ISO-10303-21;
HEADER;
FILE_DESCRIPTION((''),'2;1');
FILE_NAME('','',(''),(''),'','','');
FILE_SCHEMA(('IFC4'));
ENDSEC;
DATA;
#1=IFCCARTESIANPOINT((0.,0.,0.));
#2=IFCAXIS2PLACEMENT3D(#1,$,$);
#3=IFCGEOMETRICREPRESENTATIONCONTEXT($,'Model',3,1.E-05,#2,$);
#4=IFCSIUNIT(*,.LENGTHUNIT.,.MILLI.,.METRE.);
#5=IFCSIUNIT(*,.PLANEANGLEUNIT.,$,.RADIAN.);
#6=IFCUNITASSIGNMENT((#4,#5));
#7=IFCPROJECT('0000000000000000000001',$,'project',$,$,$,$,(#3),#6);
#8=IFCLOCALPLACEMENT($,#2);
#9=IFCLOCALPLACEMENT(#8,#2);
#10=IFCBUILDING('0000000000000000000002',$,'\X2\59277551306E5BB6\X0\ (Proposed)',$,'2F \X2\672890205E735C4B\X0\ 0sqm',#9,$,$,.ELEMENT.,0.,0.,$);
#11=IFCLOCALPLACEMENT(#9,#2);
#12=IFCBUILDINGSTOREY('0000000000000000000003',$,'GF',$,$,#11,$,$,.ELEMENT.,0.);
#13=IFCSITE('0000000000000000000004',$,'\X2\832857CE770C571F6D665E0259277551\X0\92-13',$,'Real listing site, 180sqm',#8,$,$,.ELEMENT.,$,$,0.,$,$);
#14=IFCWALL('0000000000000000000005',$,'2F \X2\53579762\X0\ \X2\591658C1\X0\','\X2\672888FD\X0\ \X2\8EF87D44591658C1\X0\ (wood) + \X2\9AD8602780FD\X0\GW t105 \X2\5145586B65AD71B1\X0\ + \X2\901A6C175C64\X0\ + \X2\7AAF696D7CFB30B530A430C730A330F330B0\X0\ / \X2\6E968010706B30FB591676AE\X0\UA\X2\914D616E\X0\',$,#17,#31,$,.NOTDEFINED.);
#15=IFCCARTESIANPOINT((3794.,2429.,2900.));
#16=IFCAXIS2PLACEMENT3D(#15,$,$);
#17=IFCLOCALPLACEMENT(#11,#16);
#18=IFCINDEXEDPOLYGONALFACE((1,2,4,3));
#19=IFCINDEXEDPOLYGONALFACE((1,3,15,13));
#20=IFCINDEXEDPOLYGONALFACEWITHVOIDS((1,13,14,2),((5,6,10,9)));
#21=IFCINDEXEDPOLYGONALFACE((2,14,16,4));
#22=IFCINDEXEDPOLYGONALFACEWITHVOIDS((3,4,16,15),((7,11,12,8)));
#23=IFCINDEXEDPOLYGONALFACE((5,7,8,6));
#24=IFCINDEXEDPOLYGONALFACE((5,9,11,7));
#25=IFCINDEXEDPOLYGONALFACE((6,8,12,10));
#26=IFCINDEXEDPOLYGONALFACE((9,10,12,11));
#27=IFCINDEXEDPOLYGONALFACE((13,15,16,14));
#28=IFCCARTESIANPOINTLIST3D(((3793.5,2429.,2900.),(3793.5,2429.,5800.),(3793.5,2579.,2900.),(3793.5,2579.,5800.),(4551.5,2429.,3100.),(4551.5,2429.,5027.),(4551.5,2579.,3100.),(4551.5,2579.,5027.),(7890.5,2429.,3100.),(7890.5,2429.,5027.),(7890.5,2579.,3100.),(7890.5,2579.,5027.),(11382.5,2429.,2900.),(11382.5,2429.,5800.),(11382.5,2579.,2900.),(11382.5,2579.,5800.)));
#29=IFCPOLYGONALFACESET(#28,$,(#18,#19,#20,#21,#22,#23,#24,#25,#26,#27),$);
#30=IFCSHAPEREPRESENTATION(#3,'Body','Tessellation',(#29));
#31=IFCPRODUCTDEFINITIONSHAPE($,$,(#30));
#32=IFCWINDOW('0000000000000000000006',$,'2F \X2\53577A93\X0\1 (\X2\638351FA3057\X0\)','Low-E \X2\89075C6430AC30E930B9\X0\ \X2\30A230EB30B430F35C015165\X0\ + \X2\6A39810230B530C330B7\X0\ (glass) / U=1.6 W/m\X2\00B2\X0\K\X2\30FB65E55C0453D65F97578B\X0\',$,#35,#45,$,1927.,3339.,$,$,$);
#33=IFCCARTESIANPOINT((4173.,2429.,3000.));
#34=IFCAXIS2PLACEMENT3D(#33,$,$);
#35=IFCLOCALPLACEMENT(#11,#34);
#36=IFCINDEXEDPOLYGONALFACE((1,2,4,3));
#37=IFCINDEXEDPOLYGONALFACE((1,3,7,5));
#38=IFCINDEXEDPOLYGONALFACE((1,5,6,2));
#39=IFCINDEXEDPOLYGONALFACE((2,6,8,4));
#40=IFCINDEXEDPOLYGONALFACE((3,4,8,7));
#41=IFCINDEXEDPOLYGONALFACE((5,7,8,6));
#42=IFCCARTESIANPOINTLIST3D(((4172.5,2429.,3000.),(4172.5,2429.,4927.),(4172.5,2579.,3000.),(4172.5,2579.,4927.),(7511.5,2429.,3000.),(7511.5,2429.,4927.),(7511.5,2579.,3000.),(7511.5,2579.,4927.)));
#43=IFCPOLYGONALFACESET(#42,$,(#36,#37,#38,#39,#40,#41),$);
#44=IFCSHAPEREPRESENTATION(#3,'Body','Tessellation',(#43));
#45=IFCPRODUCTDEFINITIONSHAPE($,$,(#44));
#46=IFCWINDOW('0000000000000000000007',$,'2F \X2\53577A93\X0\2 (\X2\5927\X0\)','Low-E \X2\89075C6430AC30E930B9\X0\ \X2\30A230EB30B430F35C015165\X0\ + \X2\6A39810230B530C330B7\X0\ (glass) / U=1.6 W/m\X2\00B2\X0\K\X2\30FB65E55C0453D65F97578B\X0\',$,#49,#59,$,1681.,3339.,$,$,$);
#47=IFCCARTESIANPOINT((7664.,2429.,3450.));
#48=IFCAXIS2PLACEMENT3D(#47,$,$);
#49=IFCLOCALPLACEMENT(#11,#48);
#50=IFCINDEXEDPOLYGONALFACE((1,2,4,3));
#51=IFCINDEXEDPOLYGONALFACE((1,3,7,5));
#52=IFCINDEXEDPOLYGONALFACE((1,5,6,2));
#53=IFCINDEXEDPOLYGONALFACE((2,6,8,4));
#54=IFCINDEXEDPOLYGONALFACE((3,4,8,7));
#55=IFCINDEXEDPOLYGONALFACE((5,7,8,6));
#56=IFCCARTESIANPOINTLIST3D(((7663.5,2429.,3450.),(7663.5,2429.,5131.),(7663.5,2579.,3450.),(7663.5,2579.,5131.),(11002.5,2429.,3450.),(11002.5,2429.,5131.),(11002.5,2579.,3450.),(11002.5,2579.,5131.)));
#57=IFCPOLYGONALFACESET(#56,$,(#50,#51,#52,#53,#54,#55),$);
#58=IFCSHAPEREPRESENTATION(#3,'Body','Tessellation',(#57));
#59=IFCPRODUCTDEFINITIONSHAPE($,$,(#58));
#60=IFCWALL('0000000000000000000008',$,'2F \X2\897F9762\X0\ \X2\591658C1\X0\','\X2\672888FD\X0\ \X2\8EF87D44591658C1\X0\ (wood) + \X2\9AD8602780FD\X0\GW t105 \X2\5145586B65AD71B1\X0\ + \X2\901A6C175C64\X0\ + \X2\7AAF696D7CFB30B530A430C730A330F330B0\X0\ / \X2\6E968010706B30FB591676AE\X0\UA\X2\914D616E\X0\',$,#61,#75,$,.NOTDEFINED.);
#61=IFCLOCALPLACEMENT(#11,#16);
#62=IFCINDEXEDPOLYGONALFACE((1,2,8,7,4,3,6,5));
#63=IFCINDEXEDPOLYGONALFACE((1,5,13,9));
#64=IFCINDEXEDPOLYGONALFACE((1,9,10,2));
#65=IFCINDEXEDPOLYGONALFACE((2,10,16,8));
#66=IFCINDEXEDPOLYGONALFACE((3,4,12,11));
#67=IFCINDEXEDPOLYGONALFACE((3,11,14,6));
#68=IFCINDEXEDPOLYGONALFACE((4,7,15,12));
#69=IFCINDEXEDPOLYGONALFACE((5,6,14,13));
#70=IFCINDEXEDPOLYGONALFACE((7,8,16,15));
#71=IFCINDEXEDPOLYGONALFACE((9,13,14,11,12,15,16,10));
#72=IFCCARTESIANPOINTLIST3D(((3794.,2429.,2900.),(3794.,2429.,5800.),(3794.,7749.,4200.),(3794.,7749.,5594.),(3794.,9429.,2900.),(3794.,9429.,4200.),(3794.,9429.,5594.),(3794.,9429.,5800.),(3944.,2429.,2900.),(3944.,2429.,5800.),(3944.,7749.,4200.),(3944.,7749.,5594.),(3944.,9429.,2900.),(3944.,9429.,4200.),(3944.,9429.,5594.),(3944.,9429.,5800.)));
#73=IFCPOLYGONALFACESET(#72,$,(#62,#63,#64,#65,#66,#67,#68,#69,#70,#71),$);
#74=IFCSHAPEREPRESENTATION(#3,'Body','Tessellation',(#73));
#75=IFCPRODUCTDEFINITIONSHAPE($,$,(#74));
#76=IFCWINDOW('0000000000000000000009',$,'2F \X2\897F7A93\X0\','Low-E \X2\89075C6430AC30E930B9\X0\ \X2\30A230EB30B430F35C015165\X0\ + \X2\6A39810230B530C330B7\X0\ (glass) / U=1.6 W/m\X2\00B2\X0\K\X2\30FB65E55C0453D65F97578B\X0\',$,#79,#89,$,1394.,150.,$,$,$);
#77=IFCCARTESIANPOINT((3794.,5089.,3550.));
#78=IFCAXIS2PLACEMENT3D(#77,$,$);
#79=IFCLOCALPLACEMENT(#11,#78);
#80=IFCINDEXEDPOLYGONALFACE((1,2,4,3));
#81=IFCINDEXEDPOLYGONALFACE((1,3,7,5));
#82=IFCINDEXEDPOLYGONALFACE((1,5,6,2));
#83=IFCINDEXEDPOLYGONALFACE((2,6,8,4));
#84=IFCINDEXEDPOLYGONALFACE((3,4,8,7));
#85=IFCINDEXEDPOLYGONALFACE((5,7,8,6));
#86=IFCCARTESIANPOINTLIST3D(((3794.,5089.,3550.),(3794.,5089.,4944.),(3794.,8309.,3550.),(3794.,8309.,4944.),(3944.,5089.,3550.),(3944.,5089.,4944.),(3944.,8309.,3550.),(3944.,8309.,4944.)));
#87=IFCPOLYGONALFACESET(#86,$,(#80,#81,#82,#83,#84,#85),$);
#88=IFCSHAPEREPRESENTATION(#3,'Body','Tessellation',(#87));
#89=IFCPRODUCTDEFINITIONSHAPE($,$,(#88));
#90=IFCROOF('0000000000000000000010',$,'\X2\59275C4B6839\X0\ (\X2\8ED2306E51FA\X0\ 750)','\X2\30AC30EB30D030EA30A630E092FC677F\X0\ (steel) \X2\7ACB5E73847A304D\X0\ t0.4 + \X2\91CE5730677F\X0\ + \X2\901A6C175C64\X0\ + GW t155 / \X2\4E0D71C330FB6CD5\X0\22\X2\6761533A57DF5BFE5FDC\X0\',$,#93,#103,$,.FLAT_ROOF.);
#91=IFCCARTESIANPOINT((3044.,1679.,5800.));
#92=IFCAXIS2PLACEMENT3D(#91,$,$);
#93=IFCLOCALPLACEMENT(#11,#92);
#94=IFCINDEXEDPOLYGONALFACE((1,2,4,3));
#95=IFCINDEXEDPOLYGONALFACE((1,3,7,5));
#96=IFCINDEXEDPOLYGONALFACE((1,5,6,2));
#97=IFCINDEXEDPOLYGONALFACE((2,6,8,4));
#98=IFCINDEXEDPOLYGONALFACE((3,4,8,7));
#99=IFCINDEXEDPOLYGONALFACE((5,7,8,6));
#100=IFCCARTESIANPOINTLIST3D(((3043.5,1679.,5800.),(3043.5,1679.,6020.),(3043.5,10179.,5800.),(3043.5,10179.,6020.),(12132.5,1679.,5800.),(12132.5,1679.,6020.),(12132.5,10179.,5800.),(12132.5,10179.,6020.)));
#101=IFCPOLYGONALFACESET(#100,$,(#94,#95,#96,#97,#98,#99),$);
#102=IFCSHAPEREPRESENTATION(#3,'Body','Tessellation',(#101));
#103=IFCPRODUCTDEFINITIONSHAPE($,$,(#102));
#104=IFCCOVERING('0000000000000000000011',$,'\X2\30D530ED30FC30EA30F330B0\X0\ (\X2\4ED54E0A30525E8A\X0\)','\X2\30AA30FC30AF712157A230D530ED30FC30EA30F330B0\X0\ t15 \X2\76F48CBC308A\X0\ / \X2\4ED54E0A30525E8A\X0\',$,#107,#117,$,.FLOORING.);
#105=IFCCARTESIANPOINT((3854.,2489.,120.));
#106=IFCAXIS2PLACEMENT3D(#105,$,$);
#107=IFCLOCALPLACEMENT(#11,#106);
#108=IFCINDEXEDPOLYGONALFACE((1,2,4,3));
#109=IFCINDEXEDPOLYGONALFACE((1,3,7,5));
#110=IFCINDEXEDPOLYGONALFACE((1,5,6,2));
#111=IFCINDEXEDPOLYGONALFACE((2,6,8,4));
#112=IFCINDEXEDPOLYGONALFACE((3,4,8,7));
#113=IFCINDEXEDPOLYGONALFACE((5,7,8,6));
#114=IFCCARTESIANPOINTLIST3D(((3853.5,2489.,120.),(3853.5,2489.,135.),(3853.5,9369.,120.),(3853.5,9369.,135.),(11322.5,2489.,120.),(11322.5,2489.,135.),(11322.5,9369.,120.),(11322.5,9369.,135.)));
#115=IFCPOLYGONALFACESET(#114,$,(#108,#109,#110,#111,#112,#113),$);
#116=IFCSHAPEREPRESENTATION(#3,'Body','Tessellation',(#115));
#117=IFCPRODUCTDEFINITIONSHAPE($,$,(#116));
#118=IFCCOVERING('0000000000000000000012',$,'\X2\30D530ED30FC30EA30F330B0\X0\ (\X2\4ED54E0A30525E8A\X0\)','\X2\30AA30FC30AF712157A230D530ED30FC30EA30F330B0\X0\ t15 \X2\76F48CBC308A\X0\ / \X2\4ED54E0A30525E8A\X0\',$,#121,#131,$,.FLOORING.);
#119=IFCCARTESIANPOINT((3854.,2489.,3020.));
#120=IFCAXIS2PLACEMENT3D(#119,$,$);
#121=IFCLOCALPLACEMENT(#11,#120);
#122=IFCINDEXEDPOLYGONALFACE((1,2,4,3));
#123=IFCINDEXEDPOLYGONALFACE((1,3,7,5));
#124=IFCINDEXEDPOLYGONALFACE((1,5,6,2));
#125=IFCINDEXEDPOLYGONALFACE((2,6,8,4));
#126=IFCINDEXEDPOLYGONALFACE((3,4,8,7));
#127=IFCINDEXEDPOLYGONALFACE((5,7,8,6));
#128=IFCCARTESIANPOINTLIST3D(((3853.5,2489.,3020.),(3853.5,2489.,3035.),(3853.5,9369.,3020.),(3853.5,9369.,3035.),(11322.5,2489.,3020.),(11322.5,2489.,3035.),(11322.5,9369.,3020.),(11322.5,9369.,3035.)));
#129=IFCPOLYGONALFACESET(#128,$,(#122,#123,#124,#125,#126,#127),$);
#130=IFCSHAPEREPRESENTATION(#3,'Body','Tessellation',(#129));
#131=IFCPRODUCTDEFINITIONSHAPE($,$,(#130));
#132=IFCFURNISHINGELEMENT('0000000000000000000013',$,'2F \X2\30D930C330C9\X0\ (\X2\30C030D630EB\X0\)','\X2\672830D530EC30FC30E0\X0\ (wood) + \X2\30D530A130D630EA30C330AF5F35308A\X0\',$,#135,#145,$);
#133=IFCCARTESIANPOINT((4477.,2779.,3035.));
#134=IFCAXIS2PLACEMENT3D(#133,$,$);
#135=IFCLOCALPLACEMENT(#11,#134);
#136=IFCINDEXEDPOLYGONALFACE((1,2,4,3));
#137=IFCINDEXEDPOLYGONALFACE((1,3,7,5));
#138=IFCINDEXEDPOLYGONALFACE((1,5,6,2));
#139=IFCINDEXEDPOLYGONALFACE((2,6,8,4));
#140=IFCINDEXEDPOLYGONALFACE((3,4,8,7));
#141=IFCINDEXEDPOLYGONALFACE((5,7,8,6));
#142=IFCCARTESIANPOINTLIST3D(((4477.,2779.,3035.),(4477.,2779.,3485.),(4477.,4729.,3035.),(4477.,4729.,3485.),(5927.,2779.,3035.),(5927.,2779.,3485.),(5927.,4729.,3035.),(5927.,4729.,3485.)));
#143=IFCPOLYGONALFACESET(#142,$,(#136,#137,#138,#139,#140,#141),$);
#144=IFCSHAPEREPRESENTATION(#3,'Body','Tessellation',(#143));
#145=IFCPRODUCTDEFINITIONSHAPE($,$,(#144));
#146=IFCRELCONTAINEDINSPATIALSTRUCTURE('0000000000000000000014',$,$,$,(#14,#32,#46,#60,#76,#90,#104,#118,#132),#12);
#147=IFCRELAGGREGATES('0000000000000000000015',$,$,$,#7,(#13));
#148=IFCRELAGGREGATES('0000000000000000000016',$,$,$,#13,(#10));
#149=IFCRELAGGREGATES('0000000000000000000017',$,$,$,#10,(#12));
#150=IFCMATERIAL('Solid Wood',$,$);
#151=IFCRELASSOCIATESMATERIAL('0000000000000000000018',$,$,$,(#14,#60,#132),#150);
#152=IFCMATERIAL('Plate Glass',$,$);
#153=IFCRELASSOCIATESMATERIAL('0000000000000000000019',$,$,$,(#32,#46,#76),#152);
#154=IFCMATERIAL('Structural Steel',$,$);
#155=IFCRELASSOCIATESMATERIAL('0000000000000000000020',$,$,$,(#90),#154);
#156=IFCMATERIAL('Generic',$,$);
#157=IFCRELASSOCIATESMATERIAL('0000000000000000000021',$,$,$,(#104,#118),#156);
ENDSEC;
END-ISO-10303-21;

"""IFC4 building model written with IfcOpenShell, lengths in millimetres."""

from ifc_helpers import new_model, si_unit, frame, frame_2d, origin, place, context, project, spatial, rectangle, extrude, material, element, fill, save


model = new_model("IFC4")

# Units and contexts
model_context = context("Model", 3, precision=1e-05, world=origin())
ifc_project = project(units=[si_unit("LENGTHUNIT", "METRE", prefix="MILLI"), si_unit("PLANEANGLEUNIT", "RADIAN")], contexts=[model_context])

# Site, building, storey
site_placement = place(None, origin())
site = spatial("IfcSite", under=ifc_project, at=site_placement, Name="茨城県土浦市大畑92-13", ObjectType="Real listing site, 180sqm", CompositionType="ELEMENT", RefElevation=0.0)
building_placement = place(site_placement, origin())
building = spatial("IfcBuilding", under=site, at=building_placement, Name="大畑の家 (Proposed)", ObjectType="2F 木造平屋 0sqm", CompositionType="ELEMENT", ElevationOfRefHeight=0.0, ElevationOfTerrain=0.0)
storey_placement = place(building_placement, origin())
storey = spatial("IfcBuildingStorey", under=building, at=storey_placement, Name="GF", CompositionType="ELEMENT", Elevation=0.0)

# Shared definitions
ifc_material_1 = material(Name="Solid Wood")

# Shared definitions
ifc_material_2 = material(Name="Plate Glass")

# Wall, openings, windows
wall_1_placement = place(storey_placement, frame((3794.0, 2429.0, 2900.0)))
wall_1 = element("IfcWall", 1, at=wall_1_placement, inside=storey, material=ifc_material_1, Name="2F 南面 外壁", Description="木製 軸組外壁 (wood) + 高性能GW t105 充填断熱 + 通気層 + 窯業系サイディング / 準耐火・外皮UA配慮", PredefinedType="NOTDEFINED", context=model_context, shape_type="SweptSolid", body=[
    extrude(rectangle(XDim=7589.0, YDim=150.0, at=frame_2d((3794.0, 75.0))), frame((3794.0, 2429.0, 2900.0)), (0.0, 0.0, 1.0), 2900.0),
])
opening_1_placement = place(storey_placement, frame((4173.0, 2429.0, 3000.0)))
opening_1 = element("IfcOpeningElement", 2, at=opening_1_placement, cuts=wall_1, PredefinedType="NOTDEFINED", context=model_context, shape_type="SweptSolid", body=[
    extrude(rectangle(XDim=3339.0, YDim=150.0, at=frame_2d((1669.0, 75.0))), frame((4173.0, 2429.0, 3000.0)), (0.0, 0.0, 1.0), 1927.0),
])
opening_2_placement = place(storey_placement, frame((7664.0, 2429.0, 3450.0)))
opening_2 = element("IfcOpeningElement", 3, at=opening_2_placement, cuts=wall_1, PredefinedType="NOTDEFINED", context=model_context, shape_type="SweptSolid", body=[
    extrude(rectangle(XDim=3339.0, YDim=150.0, at=frame_2d((1669.0, 75.0))), frame((7664.0, 2429.0, 3450.0)), (0.0, 0.0, 1.0), 1681.0),
])
window_1_placement = place(storey_placement, frame((4173.0, 2429.0, 3000.0)))
window_1 = element("IfcWindow", 4, at=window_1_placement, inside=storey, material=ifc_material_2, Name="2F 南窓1 (掃出し)", Description="Low-E 複層ガラス アルゴン封入 + 樹脂サッシ (glass) / U=1.6 W/m²K・日射取得型", OverallHeight=1927.0, OverallWidth=3339.0, context=model_context, shape_type="SweptSolid", body=[
    extrude(rectangle(XDim=3339.0, YDim=150.0, at=frame_2d((1669.0, 75.0))), frame((4173.0, 2429.0, 3000.0)), (0.0, 0.0, 1.0), 1927.0),
])
fill(opening_1, window_1)
window_2_placement = place(storey_placement, frame((7664.0, 2429.0, 3450.0)))
window_2 = element("IfcWindow", 5, at=window_2_placement, inside=storey, material=ifc_material_2, Name="2F 南窓2 (大)", Description="Low-E 複層ガラス アルゴン封入 + 樹脂サッシ (glass) / U=1.6 W/m²K・日射取得型", OverallHeight=1681.0, OverallWidth=3339.0, context=model_context, shape_type="SweptSolid", body=[
    extrude(rectangle(XDim=3339.0, YDim=150.0, at=frame_2d((1669.0, 75.0))), frame((7664.0, 2429.0, 3450.0)), (0.0, 0.0, 1.0), 1681.0),
])
fill(opening_2, window_2)

# Wall, opening, window
wall_2_placement = place(storey_placement, frame((3794.0, 2429.0, 2900.0)))
wall_2 = element("IfcWall", 6, at=wall_2_placement, inside=storey, material=ifc_material_1, Name="2F 西面 外壁", Description="木製 軸組外壁 (wood) + 高性能GW t105 充填断熱 + 通気層 + 窯業系サイディング / 準耐火・外皮UA配慮", PredefinedType="NOTDEFINED", context=model_context, shape_type="SweptSolid", body=[
    extrude(rectangle(XDim=150.0, YDim=7000.0, at=frame_2d((75.0, 3500.0))), frame((3794.0, 2429.0, 2900.0)), (0.0, 0.0, 1.0), 2900.0),
])
opening_3_placement = place(storey_placement, frame((3794.0, 5089.0, 3550.0)))
opening_3 = element("IfcOpeningElement", 7, at=opening_3_placement, cuts=wall_2, PredefinedType="NOTDEFINED", context=model_context, shape_type="SweptSolid", body=[
    extrude(rectangle(XDim=150.0, YDim=3220.0, at=frame_2d((75.0, 1610.0))), frame((3794.0, 5089.0, 3550.0)), (0.0, 0.0, 1.0), 1394.0),
])
window_3_placement = place(storey_placement, frame((3794.0, 5089.0, 3550.0)))
window_3 = element("IfcWindow", 8, at=window_3_placement, inside=storey, material=ifc_material_2, Name="2F 西窓", Description="Low-E 複層ガラス アルゴン封入 + 樹脂サッシ (glass) / U=1.6 W/m²K・日射取得型", OverallHeight=1394.0, OverallWidth=150.0, context=model_context, shape_type="SweptSolid", body=[
    extrude(rectangle(XDim=150.0, YDim=3220.0, at=frame_2d((75.0, 1610.0))), frame((3794.0, 5089.0, 3550.0)), (0.0, 0.0, 1.0), 1394.0),
])
fill(opening_3, window_3)

# Roof
ifc_material_3 = material(Name="Structural Steel")
roof_placement = place(storey_placement, frame((3044.0, 1679.0, 5800.0)))
element("IfcRoof", 9, at=roof_placement, inside=storey, material=ifc_material_3, Name="大屋根 (軒の出 750)", Description="ガルバリウム鋼板 (steel) 立平葺き t0.4 + 野地板 + 通気層 + GW t155 / 不燃・法22条区域対応", PredefinedType="FLAT_ROOF", context=model_context, shape_type="SweptSolid", body=[
    extrude(rectangle(XDim=9089.0, YDim=8500.0, at=frame_2d((4544.0, 4250.0))), frame((3044.0, 1679.0, 5800.0)), (0.0, 0.0, 1.0), 220.0),
])

# Coverings
ifc_material_4 = material(Name="Generic")
covering_1_placement = place(storey_placement, frame((3854.0, 2489.0, 120.0)))
element("IfcCovering", 10, at=covering_1_placement, inside=storey, material=ifc_material_4, Name="フローリング (仕上げ床)", Description="オーク無垢フローリング t15 直貼り / 仕上げ床", PredefinedType="FLOORING", context=model_context, shape_type="SweptSolid", body=[
    extrude(rectangle(XDim=7469.0, YDim=6880.0, at=frame_2d((3734.0, 3440.0))), frame((3854.0, 2489.0, 120.0)), (0.0, 0.0, 1.0), 15.0),
])
covering_2_placement = place(storey_placement, frame((3854.0, 2489.0, 3020.0)))
element("IfcCovering", 11, at=covering_2_placement, inside=storey, material=ifc_material_4, Name="フローリング (仕上げ床)", Description="オーク無垢フローリング t15 直貼り / 仕上げ床", PredefinedType="FLOORING", context=model_context, shape_type="SweptSolid", body=[
    extrude(rectangle(XDim=7469.0, YDim=6880.0, at=frame_2d((3734.0, 3440.0))), frame((3854.0, 2489.0, 3020.0)), (0.0, 0.0, 1.0), 15.0),
])

# Furnishing element
furnishing_placement = place(storey_placement, frame((4477.0, 2779.0, 3035.0)))
element("IfcFurnishingElement", 12, at=furnishing_placement, inside=storey, material=ifc_material_1, Name="2F ベッド (ダブル)", Description="木フレーム (wood) + ファブリック張り", context=model_context, shape_type="SweptSolid", body=[
    extrude(rectangle(XDim=1450.0, YDim=1950.0, at=frame_2d((725.0, 975.0))), frame((4477.0, 2779.0, 3035.0)), (0.0, 0.0, 1.0), 450.0),
])

save(model, "model.ifc")
